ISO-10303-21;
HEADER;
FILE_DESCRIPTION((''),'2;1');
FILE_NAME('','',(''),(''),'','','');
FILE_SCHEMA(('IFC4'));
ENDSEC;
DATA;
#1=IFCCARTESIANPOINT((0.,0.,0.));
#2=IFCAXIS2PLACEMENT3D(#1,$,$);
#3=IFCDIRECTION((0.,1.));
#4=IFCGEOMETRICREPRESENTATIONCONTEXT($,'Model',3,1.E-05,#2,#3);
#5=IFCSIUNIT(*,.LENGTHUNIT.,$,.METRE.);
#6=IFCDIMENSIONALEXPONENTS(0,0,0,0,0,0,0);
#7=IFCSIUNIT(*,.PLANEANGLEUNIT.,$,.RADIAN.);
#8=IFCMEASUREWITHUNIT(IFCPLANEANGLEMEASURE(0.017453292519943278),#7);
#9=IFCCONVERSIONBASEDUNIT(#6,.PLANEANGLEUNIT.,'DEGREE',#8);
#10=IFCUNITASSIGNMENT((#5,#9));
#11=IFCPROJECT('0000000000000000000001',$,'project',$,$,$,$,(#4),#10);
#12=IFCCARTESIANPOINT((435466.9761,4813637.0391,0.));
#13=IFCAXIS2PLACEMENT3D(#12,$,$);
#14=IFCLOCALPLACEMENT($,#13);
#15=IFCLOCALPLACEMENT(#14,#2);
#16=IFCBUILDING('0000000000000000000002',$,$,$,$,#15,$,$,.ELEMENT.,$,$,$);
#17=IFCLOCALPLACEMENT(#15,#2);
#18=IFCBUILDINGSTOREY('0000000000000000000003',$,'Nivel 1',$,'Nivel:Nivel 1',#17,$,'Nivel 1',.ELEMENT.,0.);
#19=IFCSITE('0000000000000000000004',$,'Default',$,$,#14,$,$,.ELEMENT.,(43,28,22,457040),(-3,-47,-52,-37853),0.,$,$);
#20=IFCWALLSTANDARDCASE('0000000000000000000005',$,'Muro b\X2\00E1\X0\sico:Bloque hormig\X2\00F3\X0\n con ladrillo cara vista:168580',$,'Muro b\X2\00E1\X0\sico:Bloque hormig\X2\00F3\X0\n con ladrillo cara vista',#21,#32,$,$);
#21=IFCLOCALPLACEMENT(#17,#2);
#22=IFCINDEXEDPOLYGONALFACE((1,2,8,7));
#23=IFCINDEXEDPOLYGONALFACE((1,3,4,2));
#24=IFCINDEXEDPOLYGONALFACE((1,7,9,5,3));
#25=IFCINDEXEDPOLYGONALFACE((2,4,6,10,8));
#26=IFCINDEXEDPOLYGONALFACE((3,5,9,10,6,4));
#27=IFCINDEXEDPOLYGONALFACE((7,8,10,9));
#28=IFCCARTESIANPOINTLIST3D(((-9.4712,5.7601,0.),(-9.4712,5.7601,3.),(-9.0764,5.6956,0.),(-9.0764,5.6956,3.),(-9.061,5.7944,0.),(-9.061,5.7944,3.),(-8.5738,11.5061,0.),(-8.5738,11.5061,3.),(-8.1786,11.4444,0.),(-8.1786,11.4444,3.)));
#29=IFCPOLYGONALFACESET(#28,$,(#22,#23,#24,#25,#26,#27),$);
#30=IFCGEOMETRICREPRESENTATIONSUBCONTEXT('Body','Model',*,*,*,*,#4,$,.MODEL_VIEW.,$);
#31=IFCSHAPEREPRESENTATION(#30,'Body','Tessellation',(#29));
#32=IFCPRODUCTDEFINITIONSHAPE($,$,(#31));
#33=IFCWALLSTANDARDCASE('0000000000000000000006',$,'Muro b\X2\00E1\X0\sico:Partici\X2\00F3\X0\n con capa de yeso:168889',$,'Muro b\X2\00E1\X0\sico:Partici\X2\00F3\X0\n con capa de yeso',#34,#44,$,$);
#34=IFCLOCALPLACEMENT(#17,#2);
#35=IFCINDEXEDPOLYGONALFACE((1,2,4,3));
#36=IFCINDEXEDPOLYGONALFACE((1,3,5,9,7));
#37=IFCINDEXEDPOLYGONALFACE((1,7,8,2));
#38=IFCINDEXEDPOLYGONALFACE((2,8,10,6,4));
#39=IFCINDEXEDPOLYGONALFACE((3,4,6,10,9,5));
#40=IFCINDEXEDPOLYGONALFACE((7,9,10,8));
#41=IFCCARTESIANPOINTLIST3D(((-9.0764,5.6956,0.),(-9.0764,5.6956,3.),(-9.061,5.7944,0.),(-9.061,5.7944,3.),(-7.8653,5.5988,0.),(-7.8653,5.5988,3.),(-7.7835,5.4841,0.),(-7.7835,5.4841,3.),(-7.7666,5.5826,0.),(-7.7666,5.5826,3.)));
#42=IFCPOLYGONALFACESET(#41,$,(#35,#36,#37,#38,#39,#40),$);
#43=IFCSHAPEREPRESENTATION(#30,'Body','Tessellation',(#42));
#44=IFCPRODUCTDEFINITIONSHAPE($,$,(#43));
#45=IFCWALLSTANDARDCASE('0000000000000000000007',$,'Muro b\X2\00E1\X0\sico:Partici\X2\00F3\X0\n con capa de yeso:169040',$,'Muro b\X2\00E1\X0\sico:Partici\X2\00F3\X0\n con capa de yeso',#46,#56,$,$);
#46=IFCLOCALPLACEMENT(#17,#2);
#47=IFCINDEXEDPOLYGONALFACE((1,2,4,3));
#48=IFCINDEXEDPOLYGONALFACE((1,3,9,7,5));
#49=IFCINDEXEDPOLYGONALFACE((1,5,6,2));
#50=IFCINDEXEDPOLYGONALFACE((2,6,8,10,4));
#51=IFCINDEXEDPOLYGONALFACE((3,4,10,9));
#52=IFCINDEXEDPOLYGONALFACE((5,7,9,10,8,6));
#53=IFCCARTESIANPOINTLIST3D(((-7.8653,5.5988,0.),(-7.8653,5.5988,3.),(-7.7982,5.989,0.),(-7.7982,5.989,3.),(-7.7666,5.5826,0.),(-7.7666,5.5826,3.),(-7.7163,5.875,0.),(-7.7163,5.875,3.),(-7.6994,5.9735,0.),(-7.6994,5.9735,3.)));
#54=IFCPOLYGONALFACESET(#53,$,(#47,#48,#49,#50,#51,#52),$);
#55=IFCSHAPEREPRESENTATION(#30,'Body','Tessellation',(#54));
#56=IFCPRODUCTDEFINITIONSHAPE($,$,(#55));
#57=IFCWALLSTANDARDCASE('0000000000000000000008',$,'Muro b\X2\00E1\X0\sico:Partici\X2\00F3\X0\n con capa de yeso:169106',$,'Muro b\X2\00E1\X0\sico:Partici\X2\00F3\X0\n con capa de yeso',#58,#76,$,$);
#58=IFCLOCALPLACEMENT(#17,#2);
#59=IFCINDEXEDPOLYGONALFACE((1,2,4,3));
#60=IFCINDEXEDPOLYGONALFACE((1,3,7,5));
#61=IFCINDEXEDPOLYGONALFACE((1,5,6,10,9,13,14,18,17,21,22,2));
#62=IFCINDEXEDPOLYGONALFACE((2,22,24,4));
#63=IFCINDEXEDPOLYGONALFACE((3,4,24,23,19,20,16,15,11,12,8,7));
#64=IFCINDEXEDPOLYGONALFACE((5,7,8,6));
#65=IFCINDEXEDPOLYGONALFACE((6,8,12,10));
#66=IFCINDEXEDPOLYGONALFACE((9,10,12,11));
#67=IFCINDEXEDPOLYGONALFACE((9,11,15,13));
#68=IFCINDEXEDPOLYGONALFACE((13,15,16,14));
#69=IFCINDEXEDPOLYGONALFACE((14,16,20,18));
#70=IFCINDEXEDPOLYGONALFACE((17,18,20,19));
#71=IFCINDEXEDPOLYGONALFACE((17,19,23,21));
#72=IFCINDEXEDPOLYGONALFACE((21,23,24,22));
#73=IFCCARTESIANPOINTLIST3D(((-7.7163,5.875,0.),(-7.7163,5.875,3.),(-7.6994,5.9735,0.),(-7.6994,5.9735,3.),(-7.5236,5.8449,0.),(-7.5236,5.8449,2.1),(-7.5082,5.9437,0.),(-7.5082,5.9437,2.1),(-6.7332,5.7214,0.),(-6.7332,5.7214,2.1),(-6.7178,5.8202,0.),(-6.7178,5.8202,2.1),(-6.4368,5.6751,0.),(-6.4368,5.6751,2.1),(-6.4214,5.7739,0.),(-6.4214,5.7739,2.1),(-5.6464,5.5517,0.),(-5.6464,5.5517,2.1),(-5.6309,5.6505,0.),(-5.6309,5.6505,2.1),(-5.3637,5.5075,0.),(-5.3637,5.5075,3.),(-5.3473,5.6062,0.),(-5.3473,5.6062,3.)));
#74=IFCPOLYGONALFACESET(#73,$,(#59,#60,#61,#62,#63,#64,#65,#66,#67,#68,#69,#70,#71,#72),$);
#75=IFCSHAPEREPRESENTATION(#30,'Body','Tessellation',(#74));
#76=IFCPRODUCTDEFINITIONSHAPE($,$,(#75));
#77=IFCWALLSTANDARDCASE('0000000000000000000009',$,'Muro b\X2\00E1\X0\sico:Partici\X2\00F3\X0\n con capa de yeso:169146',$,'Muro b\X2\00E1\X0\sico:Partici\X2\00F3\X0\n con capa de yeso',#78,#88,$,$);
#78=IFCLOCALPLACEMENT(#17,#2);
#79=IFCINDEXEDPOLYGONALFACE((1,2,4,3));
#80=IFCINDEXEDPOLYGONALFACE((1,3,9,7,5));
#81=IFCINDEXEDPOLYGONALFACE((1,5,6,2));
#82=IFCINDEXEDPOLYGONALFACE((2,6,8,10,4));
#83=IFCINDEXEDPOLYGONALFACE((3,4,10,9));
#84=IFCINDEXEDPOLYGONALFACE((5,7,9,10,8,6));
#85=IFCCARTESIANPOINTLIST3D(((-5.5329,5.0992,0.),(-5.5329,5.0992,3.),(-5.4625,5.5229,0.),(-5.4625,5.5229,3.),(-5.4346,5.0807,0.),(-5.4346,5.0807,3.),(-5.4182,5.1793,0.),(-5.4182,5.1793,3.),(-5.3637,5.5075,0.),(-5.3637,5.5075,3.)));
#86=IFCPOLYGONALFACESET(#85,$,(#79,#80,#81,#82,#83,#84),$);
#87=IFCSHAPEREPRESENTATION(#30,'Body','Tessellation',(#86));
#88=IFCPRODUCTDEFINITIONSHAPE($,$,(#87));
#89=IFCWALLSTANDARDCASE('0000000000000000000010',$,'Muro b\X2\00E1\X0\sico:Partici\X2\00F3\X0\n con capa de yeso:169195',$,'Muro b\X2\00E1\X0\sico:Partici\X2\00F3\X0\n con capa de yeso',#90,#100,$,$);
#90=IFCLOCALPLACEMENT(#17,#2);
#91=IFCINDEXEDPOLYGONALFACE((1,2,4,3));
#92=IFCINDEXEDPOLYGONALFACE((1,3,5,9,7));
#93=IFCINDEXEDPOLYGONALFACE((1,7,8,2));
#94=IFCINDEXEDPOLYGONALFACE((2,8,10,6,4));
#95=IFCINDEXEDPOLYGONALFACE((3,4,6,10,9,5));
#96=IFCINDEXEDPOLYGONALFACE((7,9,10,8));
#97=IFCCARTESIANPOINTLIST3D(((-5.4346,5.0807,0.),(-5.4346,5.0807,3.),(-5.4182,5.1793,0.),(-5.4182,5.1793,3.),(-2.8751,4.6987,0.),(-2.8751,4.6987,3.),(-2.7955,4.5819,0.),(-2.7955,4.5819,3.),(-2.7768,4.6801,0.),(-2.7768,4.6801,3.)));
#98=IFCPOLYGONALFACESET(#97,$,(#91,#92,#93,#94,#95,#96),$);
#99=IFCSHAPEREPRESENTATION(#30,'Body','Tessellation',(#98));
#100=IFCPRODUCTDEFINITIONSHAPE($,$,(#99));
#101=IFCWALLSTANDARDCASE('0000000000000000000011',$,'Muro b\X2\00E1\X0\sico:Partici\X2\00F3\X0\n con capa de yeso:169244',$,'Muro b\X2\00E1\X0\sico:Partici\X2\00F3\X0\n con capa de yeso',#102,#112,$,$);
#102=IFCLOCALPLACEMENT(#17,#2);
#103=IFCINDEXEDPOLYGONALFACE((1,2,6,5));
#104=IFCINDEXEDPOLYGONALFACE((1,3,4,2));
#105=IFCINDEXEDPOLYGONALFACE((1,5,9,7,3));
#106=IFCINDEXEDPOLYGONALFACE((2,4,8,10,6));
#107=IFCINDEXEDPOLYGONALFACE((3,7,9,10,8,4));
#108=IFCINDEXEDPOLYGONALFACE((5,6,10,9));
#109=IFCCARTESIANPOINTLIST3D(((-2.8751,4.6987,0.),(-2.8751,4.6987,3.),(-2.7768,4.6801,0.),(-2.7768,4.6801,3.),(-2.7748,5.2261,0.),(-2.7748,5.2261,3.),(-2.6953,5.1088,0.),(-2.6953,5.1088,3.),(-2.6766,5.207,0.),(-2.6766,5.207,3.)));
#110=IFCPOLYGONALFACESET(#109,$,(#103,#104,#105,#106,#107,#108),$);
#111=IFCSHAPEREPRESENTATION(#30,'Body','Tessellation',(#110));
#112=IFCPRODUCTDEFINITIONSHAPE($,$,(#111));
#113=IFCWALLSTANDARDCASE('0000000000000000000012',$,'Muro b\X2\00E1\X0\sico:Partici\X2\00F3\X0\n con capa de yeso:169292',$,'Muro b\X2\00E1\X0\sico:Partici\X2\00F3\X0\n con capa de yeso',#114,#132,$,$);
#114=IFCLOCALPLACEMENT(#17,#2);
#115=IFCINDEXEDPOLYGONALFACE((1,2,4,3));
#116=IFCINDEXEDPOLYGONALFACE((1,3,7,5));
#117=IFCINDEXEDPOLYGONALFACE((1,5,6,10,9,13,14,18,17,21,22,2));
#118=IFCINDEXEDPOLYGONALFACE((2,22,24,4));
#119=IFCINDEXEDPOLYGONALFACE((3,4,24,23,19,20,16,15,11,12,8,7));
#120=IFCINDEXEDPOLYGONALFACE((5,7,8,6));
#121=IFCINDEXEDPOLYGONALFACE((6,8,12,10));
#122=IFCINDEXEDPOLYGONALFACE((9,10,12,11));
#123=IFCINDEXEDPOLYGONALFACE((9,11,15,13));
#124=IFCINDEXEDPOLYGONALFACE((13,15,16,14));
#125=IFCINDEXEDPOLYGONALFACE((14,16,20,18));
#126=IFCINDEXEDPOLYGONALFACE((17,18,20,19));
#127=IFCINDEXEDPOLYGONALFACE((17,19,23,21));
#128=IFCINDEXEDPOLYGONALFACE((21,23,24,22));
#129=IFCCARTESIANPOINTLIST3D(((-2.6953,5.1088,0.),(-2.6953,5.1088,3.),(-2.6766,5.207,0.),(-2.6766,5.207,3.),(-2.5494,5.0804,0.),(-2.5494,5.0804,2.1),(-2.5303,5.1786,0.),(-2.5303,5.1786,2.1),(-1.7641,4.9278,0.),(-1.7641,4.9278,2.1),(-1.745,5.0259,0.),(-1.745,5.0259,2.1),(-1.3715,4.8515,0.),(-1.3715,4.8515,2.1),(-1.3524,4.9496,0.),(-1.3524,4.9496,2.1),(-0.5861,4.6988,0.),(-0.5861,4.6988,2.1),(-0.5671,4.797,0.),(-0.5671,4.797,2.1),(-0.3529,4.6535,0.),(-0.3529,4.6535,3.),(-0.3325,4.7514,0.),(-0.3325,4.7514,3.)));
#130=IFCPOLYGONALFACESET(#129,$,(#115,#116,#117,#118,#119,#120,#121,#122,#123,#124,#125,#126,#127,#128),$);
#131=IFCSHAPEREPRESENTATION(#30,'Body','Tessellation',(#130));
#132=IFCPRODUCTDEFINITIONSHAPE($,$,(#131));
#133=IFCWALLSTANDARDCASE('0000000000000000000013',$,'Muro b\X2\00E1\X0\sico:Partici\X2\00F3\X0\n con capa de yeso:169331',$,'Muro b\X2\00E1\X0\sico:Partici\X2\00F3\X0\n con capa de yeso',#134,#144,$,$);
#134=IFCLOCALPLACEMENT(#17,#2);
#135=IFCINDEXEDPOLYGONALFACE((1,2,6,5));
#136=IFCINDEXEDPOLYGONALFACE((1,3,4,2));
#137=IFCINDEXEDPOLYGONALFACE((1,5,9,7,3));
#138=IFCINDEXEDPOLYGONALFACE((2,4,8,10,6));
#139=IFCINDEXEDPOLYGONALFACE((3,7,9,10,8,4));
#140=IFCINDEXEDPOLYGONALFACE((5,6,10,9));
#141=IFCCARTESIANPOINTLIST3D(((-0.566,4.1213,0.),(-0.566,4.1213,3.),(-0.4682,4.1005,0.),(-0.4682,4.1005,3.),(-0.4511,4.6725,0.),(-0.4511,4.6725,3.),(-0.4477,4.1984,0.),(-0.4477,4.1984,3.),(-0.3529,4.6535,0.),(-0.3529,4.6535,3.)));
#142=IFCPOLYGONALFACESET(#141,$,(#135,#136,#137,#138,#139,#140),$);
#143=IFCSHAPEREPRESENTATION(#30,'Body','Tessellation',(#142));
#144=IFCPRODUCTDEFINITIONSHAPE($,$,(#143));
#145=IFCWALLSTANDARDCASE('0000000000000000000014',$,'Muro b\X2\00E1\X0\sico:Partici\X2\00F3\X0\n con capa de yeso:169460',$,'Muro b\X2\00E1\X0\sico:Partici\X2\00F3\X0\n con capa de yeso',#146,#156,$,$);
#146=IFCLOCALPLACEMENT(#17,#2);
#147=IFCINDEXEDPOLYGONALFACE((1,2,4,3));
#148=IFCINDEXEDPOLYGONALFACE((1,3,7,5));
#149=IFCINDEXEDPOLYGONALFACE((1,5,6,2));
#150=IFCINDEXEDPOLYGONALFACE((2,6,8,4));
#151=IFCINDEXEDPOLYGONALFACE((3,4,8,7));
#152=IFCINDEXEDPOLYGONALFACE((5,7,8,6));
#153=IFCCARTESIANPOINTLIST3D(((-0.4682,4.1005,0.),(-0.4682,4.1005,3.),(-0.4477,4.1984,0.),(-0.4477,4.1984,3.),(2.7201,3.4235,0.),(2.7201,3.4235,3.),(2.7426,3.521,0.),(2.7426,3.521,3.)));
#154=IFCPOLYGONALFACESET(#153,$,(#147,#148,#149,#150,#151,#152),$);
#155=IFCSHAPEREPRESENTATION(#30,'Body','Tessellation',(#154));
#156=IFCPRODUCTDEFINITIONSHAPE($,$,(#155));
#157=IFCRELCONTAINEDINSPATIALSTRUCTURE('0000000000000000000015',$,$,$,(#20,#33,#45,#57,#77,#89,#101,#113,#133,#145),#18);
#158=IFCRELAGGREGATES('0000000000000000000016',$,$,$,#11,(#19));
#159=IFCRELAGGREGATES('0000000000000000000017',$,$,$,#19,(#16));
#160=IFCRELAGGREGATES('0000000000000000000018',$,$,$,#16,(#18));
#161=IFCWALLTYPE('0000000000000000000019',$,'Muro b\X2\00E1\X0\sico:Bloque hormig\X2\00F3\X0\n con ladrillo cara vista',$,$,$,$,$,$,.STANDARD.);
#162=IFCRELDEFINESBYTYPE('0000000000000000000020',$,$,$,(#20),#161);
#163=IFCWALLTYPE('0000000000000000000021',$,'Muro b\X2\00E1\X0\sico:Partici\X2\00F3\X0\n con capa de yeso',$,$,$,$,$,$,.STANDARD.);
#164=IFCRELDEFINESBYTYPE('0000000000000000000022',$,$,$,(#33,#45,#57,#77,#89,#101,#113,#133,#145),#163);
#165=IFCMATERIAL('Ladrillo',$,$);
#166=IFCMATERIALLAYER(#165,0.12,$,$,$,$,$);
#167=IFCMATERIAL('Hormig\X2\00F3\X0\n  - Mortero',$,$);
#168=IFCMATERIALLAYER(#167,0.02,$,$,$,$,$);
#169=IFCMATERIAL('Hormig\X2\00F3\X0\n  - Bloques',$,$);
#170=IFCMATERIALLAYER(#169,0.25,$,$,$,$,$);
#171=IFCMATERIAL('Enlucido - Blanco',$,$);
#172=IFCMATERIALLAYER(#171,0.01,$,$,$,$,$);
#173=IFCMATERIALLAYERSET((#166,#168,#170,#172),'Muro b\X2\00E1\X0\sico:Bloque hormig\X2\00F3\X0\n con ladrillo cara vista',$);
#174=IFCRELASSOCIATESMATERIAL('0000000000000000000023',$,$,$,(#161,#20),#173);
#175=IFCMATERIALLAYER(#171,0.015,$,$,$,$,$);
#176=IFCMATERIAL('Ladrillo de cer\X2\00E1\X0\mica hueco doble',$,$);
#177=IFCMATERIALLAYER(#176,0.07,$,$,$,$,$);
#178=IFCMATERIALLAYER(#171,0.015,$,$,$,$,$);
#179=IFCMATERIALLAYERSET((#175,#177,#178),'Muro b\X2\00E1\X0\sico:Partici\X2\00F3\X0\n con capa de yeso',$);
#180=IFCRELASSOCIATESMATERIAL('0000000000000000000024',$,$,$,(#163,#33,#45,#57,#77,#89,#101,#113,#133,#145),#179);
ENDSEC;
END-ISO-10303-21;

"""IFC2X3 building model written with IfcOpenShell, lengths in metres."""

from ifc_helpers import new_model, entity, si_unit, converted_unit, direction, frame, frame_2d, origin, place, context, subcontext, project, spatial, polyline, rectangle, outline, extrude, material, layer, layer_set, layer_usage, type_object, element, save


model = new_model("IFC2X3")

# Units and contexts
model_context = context("Model", 3, precision=1e-05, world=origin(), true_north=direction((0.0, 1.0)))
body_context = subcontext(model_context, "Body", "Model", "MODEL_VIEW")
ifc_project = project(units=[si_unit("LENGTHUNIT", "METRE"), converted_unit("PLANEANGLEUNIT", "DEGREE", entity("IfcPlaneAngleMeasure", 0.017453292519943278), si_unit("PLANEANGLEUNIT", "RADIAN"), dimensions=[0, 0, 0, 0, 0, 0, 0])], contexts=[model_context])

# Site, building, storey
site_placement = place(None, frame((435466.9761, 4813637.0391, 0.0)))
site = spatial("IfcSite", under=ifc_project, at=site_placement, Name="Default", CompositionType="ELEMENT", RefLatitude=(43, 28, 22, 457040), RefLongitude=(-3, -47, -52, -37853), RefElevation=0.0)
building_placement = place(site_placement, origin())
building = spatial("IfcBuilding", under=site, at=building_placement, CompositionType="ELEMENT")
storey_placement = place(building_placement, origin())
storey = spatial("IfcBuildingStorey", under=building, at=storey_placement, Name="Nivel 1", ObjectType="Nivel:Nivel 1", LongName="Nivel 1", CompositionType="ELEMENT", Elevation=0.0)

# Walls
ifc_material_1 = material(Name="Ladrillo")
ifc_layer_1 = layer(ifc_material_1, 0.12)
ifc_material_2 = material(Name="Hormigón  - Mortero")
ifc_layer_2 = layer(ifc_material_2, 0.02)
ifc_material_3 = material(Name="Hormigón  - Bloques")
ifc_layer_3 = layer(ifc_material_3, 0.25)
ifc_material_4 = material(Name="Enlucido - Blanco")
ifc_layer_4 = layer(ifc_material_4, 0.01)
ifc_layer_set_1 = layer_set([ifc_layer_1, ifc_layer_2, ifc_layer_3, ifc_layer_4], Name="Muro básico:Bloque hormigón con ladrillo cara vista")
wall_type_1 = type_object("IfcWallType", Name="Muro básico:Bloque hormigón con ladrillo cara vista", PredefinedType="STANDARD", material=ifc_layer_set_1)
ifc_layer_usage_1 = layer_usage(ifc_layer_set_1, "AXIS2", "POSITIVE", -0.2)
wall_1_placement = place(storey_placement, frame((-8.3762, 11.4752, 0.0), z_axis=(0.0, 0.0, 1.0), x_axis=(-0.154315, -0.988022, 0.0)))
element("IfcWallStandardCase", 1, at=wall_1_placement, inside=storey, type_object=wall_type_1, material=ifc_layer_usage_1, Name="Muro básico:Bloque hormigón con ladrillo cara vista:168580", ObjectType="Muro básico:Bloque hormigón con ladrillo cara vista", context=body_context, shape_type="SweptSolid", body=[
    extrude(outline(polyline([(5.8156, -0.2), (5.8185, 0.2), (5.7185, 0.2), (0.0, 0.2), (0.0, -0.2), (5.8156, -0.2)])), origin(), (0.0, 0.0, 1.0), 3.0),
])
ifc_layer_5 = layer(ifc_material_4, 0.015)
ifc_material_5 = material(Name="Ladrillo de cerámica hueco doble")
ifc_layer_6 = layer(ifc_material_5, 0.07)
ifc_layer_7 = layer(ifc_material_4, 0.015)
ifc_layer_set_2 = layer_set([ifc_layer_5, ifc_layer_6, ifc_layer_7], Name="Muro básico:Partición con capa de yeso")
ifc_layer_usage_2 = layer_usage(ifc_layer_set_2, "AXIS2", "POSITIVE", -0.05)
wall_type_2 = type_object("IfcWallType", Name="Muro básico:Partición con capa de yeso", PredefinedType="STANDARD", material=ifc_layer_set_2)
wall_2_placement = place(storey_placement, frame((-9.0691, 5.745, 0.0), z_axis=(0.0, 0.0, 1.0), x_axis=(0.986886, -0.161421, 0.0)))
element("IfcWallStandardCase", 2, at=wall_2_placement, inside=storey, type_object=wall_type_2, material=ifc_layer_usage_2, Name="Muro básico:Partición con capa de yeso:168889", ObjectType="Muro básico:Partición con capa de yeso", context=body_context, shape_type="SweptSolid", body=[
    extrude(outline(polyline([(1.3108, -0.05), (1.3116, 0.05), (1.2116, 0.05), (0.0, 0.05), (0.0007, -0.05), (1.3108, -0.05)])), origin(), (0.0, 0.0, 1.0), 3.0),
])
ifc_layer_usage_3 = layer_usage(ifc_layer_set_2, "AXIS2", "POSITIVE", -0.05)
wall_3_placement = place(storey_placement, frame((-7.816, 5.5903, 0.0), z_axis=(0.0, 0.0, 1.0), x_axis=(0.169385, 0.98555, 0.0)))
element("IfcWallStandardCase", 3, at=wall_3_placement, inside=storey, type_object=wall_type_2, material=ifc_layer_usage_3, Name="Muro básico:Partición con capa de yeso:169040", ObjectType="Muro básico:Partición con capa de yeso", context=body_context, shape_type="SweptSolid", body=[
    extrude(outline(polyline([(0.3974, -0.05), (0.3959, 0.05), (0.0, 0.05), (0.0008, -0.05), (0.2974, -0.05), (0.3974, -0.05)])), origin(), (0.0, 0.0, 1.0), 3.0),
])

# Wall, openings
ifc_layer_usage_4 = layer_usage(ifc_layer_set_2, "AXIS2", "POSITIVE", -0.05)
wall_4_placement = place(storey_placement, frame((-7.7086, 5.9244, 0.0), z_axis=(0.0, 0.0, 1.0), x_axis=(0.988022, -0.154315, 0.0)))
wall_4 = element("IfcWallStandardCase", 4, at=wall_4_placement, inside=storey, type_object=wall_type_2, material=ifc_layer_usage_4, Name="Muro básico:Partición con capa de yeso:169106", ObjectType="Muro básico:Partición con capa de yeso", context=body_context, shape_type="SweptSolid", body=[
    extrude(outline(polyline([(0.0, -0.05), (2.2812, -0.05), (2.3812, -0.05), (2.3822, 0.05), (0.0015, 0.05), (0.0, -0.05)])), origin(), (0.0, 0.0, 1.0), 3.0),
])
opening_1_placement = place(wall_4_placement, frame((0.1951, -0.05, 0.0)))
element("IfcOpeningElement", 5, at=opening_1_placement, cuts=wall_4, ObjectType="Opening", context=body_context, shape_type="SweptSolid", body=[
    extrude(rectangle(XDim=2.1, YDim=0.8, at=frame_2d((1.05, 0.4), x_axis=(1.0, 0.0))), frame((0.0, 0.0, 0.0), z_axis=(0.0, 1.0, 0.0), x_axis=(0.0, 0.0, 1.0)), (0.0, 0.0, 1.0), 0.1),
])
opening_2_placement = place(wall_4_placement, frame((1.2951, -0.05, 0.0)))
element("IfcOpeningElement", 6, at=opening_2_placement, cuts=wall_4, ObjectType="Opening", context=body_context, shape_type="SweptSolid", body=[
    extrude(rectangle(XDim=2.1, YDim=0.8, at=frame_2d((1.05, 0.4), x_axis=(1.0, 0.0))), frame((0.0, 0.0, 0.0), z_axis=(0.0, 1.0, 0.0), x_axis=(0.0, 0.0, 1.0)), (0.0, 0.0, 1.0), 0.1),
])

# Walls
ifc_layer_usage_5 = layer_usage(ifc_layer_set_2, "AXIS2", "POSITIVE", -0.05)
wall_5_placement = place(storey_placement, frame((-5.413, 5.5157, 0.0), z_axis=(0.0, 0.0, 1.0), x_axis=(-0.16397, -0.986465, 0.0)))
element("IfcWallStandardCase", 7, at=wall_5_placement, inside=storey, type_object=wall_type_2, material=ifc_layer_usage_5, Name="Muro básico:Partición con capa de yeso:169146", ObjectType="Muro básico:Partición con capa de yeso", context=body_context, shape_type="SweptSolid", body=[
    extrude(outline(polyline([(0.4305, -0.05), (0.4327, 0.05), (0.3327, 0.05), (0.0, 0.05), (0.001, -0.05), (0.4305, -0.05)])), origin(), (0.0, 0.0, 1.0), 3.0),
])
ifc_layer_usage_6 = layer_usage(ifc_layer_set_2, "AXIS2", "POSITIVE", -0.05)
wall_6_placement = place(storey_placement, frame((-5.4275, 5.1302, 0.0), z_axis=(0.0, 0.0, 1.0), x_axis=(0.982607, -0.185698, 0.0)))
element("IfcWallStandardCase", 8, at=wall_6_placement, inside=storey, type_object=wall_type_2, material=ifc_layer_usage_6, Name="Muro básico:Partición con capa de yeso:169195", ObjectType="Muro básico:Partición con capa de yeso", context=body_context, shape_type="SweptSolid", body=[
    extrude(outline(polyline([(2.688, -0.05), (2.6881, 0.05), (2.5881, 0.05), (0.0, 0.05), (0.0022, -0.05), (2.688, -0.05)])), origin(), (0.0, 0.0, 1.0), 3.0),
])
ifc_layer_usage_7 = layer_usage(ifc_layer_set_2, "AXIS2", "POSITIVE", -0.05)
wall_7_placement = place(storey_placement, frame((-2.826, 4.6894, 0.0), z_axis=(0.0, 0.0, 1.0), x_axis=(0.18685, 0.982388, 0.0)))
element("IfcWallStandardCase", 9, at=wall_7_placement, inside=storey, type_object=wall_type_2, material=ifc_layer_usage_7, Name="Muro básico:Partición con capa de yeso:169244", ObjectType="Muro básico:Partición con capa de yeso", context=body_context, shape_type="SweptSolid", body=[
    extrude(outline(polyline([(0.5364, -0.05), (0.5368, 0.05), (0.0, 0.05), (0.0001, -0.05), (0.4364, -0.05), (0.5364, -0.05)])), origin(), (0.0, 0.0, 1.0), 3.0),
])

# Wall, openings
ifc_layer_usage_8 = layer_usage(ifc_layer_set_2, "AXIS2", "POSITIVE", -0.05)
wall_8_placement = place(storey_placement, frame((-2.6862, 5.1579, 0.0), z_axis=(0.0, 0.0, 1.0), x_axis=(0.981627, -0.190809, 0.0)))
wall_8 = element("IfcWallStandardCase", 10, at=wall_8_placement, inside=storey, type_object=wall_type_2, material=ifc_layer_usage_8, Name="Muro básico:Partición con capa de yeso:169292", ObjectType="Muro básico:Partición con capa de yeso", context=body_context, shape_type="SweptSolid", body=[
    extrude(outline(polyline([(0.0004, -0.05), (2.2867, -0.05), (2.3867, -0.05), (2.388, 0.05), (0.0, 0.05), (0.0004, -0.05)])), origin(), (0.0, 0.0, 1.0), 3.0),
])
opening_3_placement = place(wall_8_placement, frame((1.349, -0.05, 0.0)))
element("IfcOpeningElement", 11, at=opening_3_placement, cuts=wall_8, ObjectType="Opening", context=body_context, shape_type="SweptSolid", body=[
    extrude(rectangle(XDim=2.1, YDim=0.8, at=frame_2d((1.05, 0.4), x_axis=(1.0, 0.0))), frame((0.0, 0.0, 0.0), z_axis=(0.0, 1.0, 0.0), x_axis=(0.0, 0.0, 1.0)), (0.0, 0.0, 1.0), 0.1),
])
opening_4_placement = place(wall_8_placement, frame((0.149, -0.05, 0.0)))
element("IfcOpeningElement", 12, at=opening_4_placement, cuts=wall_8, ObjectType="Opening", context=body_context, shape_type="SweptSolid", body=[
    extrude(rectangle(XDim=2.1, YDim=0.8, at=frame_2d((1.05, 0.4), x_axis=(1.0, 0.0))), frame((0.0, 0.0, 0.0), z_axis=(0.0, 1.0, 0.0), x_axis=(0.0, 0.0, 1.0)), (0.0, 0.0, 1.0), 0.1),
])

# Walls
ifc_layer_usage_9 = layer_usage(ifc_layer_set_2, "AXIS2", "NEGATIVE", 0.05)
wall_9_placement = place(storey_placement, frame((-0.4018, 4.6637, 0.0), z_axis=(0.0, 0.0, 1.0), x_axis=(-0.204054, -0.97896, 0.0)))
element("IfcWallStandardCase", 13, at=wall_9_placement, inside=storey, type_object=wall_type_2, material=ifc_layer_usage_9, Name="Muro básico:Partición con capa de yeso:169331", ObjectType="Muro básico:Partición con capa de yeso", context=body_context, shape_type="SweptSolid", body=[
    extrude(outline(polyline([(0.5645, -0.05), (0.5648, 0.05), (0.4648, 0.05), (0.0, 0.05), (0.0014, -0.05), (0.5645, -0.05)])), origin(), (0.0, 0.0, 1.0), 3.0),
])
ifc_layer_usage_10 = layer_usage(ifc_layer_set_2, "AXIS2", "NEGATIVE", 0.05)
wall_10_placement = place(storey_placement, frame((-0.4581, 4.1495, 0.0), z_axis=(0.0, 0.0, 1.0), x_axis=(0.978192, -0.207703, 0.0)))
element("IfcWallStandardCase", 14, at=wall_10_placement, inside=storey, type_object=wall_type_2, material=ifc_layer_usage_10, Name="Muro básico:Partición con capa de yeso:169460", ObjectType="Muro básico:Partición con capa de yeso", context=body_context, shape_type="SweptSolid", body=[
    extrude(outline(polyline([(3.2597, -0.05), (3.2615, 0.05), (0.0, 0.05), (0.0004, -0.05), (3.2597, -0.05)])), origin(), (0.0, 0.0, 1.0), 3.0),
])

save(model, "model.ifc")
